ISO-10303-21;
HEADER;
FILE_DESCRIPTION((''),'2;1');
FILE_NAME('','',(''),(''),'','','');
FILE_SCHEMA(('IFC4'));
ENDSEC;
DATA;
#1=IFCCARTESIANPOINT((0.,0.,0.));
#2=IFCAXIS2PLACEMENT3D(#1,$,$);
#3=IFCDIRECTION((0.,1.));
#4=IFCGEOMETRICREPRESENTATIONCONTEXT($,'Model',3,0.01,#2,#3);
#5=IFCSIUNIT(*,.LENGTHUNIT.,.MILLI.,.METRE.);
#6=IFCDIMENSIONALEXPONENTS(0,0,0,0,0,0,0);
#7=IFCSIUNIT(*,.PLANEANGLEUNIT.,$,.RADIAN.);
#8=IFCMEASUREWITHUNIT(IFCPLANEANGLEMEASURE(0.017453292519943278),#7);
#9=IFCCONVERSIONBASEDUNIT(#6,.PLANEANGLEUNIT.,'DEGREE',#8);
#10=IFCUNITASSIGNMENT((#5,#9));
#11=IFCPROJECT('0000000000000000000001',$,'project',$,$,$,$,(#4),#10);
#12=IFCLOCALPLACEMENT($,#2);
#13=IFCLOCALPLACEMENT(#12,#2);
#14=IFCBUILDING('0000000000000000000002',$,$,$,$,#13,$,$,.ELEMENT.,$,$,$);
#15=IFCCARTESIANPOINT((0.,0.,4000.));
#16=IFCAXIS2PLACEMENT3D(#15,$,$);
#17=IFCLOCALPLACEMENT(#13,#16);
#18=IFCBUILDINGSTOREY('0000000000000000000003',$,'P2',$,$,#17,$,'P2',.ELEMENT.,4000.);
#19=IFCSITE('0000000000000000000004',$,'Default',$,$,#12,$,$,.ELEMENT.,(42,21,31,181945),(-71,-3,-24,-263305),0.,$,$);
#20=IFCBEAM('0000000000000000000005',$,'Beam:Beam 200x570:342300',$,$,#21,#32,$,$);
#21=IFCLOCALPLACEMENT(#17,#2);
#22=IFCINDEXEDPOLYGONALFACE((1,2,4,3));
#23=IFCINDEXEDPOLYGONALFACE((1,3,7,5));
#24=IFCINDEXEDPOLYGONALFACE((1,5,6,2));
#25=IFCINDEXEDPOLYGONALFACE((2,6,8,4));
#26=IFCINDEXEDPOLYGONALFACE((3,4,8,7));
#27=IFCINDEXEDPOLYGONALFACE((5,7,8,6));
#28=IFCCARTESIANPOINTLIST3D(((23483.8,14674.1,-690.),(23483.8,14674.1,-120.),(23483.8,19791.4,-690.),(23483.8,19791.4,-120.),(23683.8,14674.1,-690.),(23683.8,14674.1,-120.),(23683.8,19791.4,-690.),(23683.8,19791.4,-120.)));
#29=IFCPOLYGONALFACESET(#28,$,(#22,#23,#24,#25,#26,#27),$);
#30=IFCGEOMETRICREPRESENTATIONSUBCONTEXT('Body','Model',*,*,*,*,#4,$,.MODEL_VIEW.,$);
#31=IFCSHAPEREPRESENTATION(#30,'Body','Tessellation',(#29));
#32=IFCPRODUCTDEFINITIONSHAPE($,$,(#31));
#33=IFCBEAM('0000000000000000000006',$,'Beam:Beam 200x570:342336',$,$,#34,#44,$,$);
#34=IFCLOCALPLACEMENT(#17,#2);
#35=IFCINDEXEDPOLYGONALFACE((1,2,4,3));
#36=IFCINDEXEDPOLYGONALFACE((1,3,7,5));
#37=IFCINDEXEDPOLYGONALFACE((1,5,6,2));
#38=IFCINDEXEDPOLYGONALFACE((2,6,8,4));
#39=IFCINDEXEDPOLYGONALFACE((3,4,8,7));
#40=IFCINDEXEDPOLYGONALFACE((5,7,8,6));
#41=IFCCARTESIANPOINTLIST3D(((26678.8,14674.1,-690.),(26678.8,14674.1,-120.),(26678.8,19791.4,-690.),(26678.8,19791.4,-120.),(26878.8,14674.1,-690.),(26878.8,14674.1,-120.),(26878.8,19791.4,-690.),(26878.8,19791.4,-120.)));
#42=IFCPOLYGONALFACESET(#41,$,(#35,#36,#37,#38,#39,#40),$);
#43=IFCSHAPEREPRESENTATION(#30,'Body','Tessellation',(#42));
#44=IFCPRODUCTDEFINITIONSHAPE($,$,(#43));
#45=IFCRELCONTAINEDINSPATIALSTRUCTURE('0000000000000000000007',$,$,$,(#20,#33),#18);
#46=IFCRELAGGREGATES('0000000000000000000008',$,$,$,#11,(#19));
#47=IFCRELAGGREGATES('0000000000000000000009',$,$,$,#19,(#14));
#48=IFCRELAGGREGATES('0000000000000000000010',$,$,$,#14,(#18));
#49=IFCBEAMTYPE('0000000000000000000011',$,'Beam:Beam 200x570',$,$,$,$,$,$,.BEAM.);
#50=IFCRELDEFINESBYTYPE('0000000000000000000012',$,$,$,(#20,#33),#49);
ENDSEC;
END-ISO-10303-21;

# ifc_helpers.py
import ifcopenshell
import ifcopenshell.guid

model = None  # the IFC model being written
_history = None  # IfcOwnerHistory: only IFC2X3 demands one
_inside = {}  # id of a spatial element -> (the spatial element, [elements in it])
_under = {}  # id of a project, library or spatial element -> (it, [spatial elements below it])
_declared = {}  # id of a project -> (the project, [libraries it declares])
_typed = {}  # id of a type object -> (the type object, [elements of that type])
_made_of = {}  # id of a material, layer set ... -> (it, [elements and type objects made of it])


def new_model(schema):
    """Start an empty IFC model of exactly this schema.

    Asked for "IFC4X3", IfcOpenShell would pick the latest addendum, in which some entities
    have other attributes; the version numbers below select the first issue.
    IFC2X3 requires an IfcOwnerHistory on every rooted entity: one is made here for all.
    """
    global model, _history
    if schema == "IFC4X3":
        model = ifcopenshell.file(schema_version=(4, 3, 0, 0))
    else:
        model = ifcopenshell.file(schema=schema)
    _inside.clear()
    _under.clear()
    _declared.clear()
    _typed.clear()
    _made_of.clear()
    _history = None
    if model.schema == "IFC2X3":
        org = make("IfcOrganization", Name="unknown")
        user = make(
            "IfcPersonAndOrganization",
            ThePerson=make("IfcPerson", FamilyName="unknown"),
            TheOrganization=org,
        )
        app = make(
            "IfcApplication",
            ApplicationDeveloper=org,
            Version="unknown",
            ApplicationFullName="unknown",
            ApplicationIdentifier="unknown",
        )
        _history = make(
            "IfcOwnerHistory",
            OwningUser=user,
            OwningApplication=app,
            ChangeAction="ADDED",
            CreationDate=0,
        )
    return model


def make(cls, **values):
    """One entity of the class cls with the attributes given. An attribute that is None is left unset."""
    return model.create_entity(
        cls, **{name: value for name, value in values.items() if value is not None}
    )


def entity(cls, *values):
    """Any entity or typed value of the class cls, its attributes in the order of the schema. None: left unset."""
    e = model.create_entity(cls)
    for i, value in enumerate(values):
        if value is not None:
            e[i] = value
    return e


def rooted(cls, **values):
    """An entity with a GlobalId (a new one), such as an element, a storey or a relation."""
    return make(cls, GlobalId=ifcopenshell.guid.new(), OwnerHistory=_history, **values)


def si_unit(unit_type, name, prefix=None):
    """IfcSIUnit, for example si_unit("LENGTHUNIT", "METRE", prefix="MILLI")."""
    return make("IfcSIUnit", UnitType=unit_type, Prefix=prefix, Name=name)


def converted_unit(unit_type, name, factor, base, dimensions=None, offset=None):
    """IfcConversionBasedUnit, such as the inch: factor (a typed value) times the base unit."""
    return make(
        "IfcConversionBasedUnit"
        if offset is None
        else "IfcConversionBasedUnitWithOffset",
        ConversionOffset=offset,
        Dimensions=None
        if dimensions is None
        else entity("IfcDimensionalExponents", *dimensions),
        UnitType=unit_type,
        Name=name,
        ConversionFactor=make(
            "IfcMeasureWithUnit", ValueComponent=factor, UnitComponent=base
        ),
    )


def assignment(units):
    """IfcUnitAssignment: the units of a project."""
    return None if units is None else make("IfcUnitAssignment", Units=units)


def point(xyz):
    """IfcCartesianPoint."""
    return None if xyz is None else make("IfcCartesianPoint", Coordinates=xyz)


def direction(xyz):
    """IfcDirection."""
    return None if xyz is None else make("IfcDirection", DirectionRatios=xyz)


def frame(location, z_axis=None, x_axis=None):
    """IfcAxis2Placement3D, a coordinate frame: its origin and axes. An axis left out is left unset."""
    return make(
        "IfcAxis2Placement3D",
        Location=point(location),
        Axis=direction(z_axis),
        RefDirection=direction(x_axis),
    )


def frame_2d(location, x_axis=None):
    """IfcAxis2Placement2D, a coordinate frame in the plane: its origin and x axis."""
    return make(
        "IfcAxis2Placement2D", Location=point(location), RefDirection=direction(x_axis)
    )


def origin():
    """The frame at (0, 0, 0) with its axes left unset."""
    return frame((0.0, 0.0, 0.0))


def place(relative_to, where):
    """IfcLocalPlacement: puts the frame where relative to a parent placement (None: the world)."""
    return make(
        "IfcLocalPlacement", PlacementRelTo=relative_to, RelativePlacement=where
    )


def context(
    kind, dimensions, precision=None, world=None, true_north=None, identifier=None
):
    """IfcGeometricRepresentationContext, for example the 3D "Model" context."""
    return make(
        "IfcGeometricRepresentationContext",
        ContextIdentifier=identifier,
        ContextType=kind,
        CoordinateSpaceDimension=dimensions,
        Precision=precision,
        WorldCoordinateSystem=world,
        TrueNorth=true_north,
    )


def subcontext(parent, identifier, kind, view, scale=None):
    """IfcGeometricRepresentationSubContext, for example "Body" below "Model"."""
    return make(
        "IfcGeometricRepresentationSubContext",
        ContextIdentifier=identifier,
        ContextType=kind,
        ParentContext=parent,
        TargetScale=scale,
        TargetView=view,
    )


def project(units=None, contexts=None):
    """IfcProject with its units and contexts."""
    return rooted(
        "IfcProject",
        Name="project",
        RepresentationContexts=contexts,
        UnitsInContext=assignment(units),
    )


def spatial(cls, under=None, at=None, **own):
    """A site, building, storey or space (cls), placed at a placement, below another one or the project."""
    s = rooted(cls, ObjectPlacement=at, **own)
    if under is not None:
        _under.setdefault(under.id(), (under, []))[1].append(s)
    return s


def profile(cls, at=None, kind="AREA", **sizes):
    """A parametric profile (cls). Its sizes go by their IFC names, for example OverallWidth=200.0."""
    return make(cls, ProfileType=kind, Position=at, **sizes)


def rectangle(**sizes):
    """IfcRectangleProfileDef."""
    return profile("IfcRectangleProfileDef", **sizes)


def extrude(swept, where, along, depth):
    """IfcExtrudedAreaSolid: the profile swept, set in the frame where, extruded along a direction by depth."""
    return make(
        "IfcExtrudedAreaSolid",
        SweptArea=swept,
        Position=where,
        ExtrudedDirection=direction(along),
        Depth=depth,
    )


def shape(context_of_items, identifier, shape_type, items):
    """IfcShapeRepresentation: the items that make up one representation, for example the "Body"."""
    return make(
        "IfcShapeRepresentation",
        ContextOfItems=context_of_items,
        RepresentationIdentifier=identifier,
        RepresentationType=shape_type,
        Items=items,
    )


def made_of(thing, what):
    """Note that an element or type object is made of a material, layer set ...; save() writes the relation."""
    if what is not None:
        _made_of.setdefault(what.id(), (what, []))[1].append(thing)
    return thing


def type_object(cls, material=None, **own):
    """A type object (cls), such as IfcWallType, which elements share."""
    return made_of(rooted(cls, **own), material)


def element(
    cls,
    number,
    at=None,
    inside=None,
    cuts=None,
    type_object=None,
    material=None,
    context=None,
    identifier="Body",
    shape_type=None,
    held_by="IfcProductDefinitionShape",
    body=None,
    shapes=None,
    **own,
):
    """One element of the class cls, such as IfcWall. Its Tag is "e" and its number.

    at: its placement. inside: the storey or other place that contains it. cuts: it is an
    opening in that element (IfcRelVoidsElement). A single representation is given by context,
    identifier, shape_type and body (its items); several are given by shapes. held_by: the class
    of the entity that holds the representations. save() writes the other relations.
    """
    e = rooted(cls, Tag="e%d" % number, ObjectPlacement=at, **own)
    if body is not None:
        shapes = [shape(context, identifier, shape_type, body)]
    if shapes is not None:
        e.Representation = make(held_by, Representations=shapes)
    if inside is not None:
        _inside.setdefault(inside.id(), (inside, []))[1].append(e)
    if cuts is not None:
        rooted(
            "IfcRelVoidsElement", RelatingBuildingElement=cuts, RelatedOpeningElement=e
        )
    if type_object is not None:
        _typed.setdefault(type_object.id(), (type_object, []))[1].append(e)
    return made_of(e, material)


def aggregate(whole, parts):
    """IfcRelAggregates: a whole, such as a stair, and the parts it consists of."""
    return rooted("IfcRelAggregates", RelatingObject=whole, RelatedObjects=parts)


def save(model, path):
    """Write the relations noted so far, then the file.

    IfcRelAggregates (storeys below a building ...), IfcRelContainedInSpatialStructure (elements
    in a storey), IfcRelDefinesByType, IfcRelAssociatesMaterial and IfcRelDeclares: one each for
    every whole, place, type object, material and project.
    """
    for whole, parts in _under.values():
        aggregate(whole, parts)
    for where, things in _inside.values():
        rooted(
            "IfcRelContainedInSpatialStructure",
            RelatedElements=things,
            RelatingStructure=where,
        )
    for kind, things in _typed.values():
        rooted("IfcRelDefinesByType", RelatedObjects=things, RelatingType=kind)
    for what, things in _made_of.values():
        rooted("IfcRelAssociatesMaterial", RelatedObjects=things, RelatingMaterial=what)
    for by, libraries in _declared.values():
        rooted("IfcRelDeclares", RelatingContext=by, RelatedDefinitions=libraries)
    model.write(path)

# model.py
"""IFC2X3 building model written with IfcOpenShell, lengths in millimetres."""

from ifc_helpers import new_model, entity, si_unit, converted_unit, direction, frame, frame_2d, origin, place, context, subcontext, project, spatial, rectangle, extrude, type_object, element, save


model = new_model("IFC2X3")

# Units and contexts
model_context = context("Model", 3, precision=0.01, world=origin(), true_north=direction((0.0, 1.0)))
body_context = subcontext(model_context, "Body", "Model", "MODEL_VIEW")
ifc_project = project(units=[si_unit("LENGTHUNIT", "METRE", prefix="MILLI"), converted_unit("PLANEANGLEUNIT", "DEGREE", entity("IfcPlaneAngleMeasure", 0.017453292519943278), si_unit("PLANEANGLEUNIT", "RADIAN"), dimensions=[0, 0, 0, 0, 0, 0, 0])], contexts=[model_context])

# Site, building, storey
site_placement = place(None, origin())
site = spatial("IfcSite", under=ifc_project, at=site_placement, Name="Default", CompositionType="ELEMENT", RefLatitude=(42, 21, 31, 181945), RefLongitude=(-71, -3, -24, -263305), RefElevation=0.0)
building_placement = place(site_placement, origin())
building = spatial("IfcBuilding", under=site, at=building_placement, CompositionType="ELEMENT")
storey_placement = place(building_placement, frame((0.0, 0.0, 4000.0)))
storey = spatial("IfcBuildingStorey", under=building, at=storey_placement, Name="P2", LongName="P2", CompositionType="ELEMENT", Elevation=4000.0)

# Beams
beam_type_1 = type_object("IfcBeamType", Name="Beam:Beam 200x570", PredefinedType="BEAM")
beam_1_placement = place(storey_placement, frame((23558.8, 19791.4, -120.0), z_axis=(0.0, 0.0, 1.0), x_axis=(0.0, -1.0, 0.0)))
element("IfcBeam", 1, at=beam_1_placement, inside=storey, type_object=beam_type_1, Name="Beam:Beam 200x570:342300", context=body_context, shape_type="SweptSolid", body=[
    extrude(rectangle(XDim=570.0, YDim=200.0, at=frame_2d((0.0, 0.0), x_axis=(1.0, 0.0))), frame((0.0, 25.0, -285.0), z_axis=(1.0, 0.0, 0.0), x_axis=(0.0, 0.0, -1.0)), (0.0, 0.0, 1.0), 5117.3),
])
beam_2_placement = place(storey_placement, frame((26753.8, 19791.4, -120.0), z_axis=(0.0, 0.0, 1.0), x_axis=(0.0, -1.0, 0.0)))
element("IfcBeam", 2, at=beam_2_placement, inside=storey, type_object=beam_type_1, Name="Beam:Beam 200x570:342336", context=body_context, shape_type="SweptSolid", body=[
    extrude(rectangle(XDim=570.0, YDim=200.0, at=frame_2d((0.0, 0.0), x_axis=(1.0, 0.0))), frame((0.0, 25.0, -285.0), z_axis=(1.0, 0.0, 0.0), x_axis=(0.0, 0.0, -1.0)), (0.0, 0.0, 1.0), 5117.3),
])

save(model, "model.ifc")
